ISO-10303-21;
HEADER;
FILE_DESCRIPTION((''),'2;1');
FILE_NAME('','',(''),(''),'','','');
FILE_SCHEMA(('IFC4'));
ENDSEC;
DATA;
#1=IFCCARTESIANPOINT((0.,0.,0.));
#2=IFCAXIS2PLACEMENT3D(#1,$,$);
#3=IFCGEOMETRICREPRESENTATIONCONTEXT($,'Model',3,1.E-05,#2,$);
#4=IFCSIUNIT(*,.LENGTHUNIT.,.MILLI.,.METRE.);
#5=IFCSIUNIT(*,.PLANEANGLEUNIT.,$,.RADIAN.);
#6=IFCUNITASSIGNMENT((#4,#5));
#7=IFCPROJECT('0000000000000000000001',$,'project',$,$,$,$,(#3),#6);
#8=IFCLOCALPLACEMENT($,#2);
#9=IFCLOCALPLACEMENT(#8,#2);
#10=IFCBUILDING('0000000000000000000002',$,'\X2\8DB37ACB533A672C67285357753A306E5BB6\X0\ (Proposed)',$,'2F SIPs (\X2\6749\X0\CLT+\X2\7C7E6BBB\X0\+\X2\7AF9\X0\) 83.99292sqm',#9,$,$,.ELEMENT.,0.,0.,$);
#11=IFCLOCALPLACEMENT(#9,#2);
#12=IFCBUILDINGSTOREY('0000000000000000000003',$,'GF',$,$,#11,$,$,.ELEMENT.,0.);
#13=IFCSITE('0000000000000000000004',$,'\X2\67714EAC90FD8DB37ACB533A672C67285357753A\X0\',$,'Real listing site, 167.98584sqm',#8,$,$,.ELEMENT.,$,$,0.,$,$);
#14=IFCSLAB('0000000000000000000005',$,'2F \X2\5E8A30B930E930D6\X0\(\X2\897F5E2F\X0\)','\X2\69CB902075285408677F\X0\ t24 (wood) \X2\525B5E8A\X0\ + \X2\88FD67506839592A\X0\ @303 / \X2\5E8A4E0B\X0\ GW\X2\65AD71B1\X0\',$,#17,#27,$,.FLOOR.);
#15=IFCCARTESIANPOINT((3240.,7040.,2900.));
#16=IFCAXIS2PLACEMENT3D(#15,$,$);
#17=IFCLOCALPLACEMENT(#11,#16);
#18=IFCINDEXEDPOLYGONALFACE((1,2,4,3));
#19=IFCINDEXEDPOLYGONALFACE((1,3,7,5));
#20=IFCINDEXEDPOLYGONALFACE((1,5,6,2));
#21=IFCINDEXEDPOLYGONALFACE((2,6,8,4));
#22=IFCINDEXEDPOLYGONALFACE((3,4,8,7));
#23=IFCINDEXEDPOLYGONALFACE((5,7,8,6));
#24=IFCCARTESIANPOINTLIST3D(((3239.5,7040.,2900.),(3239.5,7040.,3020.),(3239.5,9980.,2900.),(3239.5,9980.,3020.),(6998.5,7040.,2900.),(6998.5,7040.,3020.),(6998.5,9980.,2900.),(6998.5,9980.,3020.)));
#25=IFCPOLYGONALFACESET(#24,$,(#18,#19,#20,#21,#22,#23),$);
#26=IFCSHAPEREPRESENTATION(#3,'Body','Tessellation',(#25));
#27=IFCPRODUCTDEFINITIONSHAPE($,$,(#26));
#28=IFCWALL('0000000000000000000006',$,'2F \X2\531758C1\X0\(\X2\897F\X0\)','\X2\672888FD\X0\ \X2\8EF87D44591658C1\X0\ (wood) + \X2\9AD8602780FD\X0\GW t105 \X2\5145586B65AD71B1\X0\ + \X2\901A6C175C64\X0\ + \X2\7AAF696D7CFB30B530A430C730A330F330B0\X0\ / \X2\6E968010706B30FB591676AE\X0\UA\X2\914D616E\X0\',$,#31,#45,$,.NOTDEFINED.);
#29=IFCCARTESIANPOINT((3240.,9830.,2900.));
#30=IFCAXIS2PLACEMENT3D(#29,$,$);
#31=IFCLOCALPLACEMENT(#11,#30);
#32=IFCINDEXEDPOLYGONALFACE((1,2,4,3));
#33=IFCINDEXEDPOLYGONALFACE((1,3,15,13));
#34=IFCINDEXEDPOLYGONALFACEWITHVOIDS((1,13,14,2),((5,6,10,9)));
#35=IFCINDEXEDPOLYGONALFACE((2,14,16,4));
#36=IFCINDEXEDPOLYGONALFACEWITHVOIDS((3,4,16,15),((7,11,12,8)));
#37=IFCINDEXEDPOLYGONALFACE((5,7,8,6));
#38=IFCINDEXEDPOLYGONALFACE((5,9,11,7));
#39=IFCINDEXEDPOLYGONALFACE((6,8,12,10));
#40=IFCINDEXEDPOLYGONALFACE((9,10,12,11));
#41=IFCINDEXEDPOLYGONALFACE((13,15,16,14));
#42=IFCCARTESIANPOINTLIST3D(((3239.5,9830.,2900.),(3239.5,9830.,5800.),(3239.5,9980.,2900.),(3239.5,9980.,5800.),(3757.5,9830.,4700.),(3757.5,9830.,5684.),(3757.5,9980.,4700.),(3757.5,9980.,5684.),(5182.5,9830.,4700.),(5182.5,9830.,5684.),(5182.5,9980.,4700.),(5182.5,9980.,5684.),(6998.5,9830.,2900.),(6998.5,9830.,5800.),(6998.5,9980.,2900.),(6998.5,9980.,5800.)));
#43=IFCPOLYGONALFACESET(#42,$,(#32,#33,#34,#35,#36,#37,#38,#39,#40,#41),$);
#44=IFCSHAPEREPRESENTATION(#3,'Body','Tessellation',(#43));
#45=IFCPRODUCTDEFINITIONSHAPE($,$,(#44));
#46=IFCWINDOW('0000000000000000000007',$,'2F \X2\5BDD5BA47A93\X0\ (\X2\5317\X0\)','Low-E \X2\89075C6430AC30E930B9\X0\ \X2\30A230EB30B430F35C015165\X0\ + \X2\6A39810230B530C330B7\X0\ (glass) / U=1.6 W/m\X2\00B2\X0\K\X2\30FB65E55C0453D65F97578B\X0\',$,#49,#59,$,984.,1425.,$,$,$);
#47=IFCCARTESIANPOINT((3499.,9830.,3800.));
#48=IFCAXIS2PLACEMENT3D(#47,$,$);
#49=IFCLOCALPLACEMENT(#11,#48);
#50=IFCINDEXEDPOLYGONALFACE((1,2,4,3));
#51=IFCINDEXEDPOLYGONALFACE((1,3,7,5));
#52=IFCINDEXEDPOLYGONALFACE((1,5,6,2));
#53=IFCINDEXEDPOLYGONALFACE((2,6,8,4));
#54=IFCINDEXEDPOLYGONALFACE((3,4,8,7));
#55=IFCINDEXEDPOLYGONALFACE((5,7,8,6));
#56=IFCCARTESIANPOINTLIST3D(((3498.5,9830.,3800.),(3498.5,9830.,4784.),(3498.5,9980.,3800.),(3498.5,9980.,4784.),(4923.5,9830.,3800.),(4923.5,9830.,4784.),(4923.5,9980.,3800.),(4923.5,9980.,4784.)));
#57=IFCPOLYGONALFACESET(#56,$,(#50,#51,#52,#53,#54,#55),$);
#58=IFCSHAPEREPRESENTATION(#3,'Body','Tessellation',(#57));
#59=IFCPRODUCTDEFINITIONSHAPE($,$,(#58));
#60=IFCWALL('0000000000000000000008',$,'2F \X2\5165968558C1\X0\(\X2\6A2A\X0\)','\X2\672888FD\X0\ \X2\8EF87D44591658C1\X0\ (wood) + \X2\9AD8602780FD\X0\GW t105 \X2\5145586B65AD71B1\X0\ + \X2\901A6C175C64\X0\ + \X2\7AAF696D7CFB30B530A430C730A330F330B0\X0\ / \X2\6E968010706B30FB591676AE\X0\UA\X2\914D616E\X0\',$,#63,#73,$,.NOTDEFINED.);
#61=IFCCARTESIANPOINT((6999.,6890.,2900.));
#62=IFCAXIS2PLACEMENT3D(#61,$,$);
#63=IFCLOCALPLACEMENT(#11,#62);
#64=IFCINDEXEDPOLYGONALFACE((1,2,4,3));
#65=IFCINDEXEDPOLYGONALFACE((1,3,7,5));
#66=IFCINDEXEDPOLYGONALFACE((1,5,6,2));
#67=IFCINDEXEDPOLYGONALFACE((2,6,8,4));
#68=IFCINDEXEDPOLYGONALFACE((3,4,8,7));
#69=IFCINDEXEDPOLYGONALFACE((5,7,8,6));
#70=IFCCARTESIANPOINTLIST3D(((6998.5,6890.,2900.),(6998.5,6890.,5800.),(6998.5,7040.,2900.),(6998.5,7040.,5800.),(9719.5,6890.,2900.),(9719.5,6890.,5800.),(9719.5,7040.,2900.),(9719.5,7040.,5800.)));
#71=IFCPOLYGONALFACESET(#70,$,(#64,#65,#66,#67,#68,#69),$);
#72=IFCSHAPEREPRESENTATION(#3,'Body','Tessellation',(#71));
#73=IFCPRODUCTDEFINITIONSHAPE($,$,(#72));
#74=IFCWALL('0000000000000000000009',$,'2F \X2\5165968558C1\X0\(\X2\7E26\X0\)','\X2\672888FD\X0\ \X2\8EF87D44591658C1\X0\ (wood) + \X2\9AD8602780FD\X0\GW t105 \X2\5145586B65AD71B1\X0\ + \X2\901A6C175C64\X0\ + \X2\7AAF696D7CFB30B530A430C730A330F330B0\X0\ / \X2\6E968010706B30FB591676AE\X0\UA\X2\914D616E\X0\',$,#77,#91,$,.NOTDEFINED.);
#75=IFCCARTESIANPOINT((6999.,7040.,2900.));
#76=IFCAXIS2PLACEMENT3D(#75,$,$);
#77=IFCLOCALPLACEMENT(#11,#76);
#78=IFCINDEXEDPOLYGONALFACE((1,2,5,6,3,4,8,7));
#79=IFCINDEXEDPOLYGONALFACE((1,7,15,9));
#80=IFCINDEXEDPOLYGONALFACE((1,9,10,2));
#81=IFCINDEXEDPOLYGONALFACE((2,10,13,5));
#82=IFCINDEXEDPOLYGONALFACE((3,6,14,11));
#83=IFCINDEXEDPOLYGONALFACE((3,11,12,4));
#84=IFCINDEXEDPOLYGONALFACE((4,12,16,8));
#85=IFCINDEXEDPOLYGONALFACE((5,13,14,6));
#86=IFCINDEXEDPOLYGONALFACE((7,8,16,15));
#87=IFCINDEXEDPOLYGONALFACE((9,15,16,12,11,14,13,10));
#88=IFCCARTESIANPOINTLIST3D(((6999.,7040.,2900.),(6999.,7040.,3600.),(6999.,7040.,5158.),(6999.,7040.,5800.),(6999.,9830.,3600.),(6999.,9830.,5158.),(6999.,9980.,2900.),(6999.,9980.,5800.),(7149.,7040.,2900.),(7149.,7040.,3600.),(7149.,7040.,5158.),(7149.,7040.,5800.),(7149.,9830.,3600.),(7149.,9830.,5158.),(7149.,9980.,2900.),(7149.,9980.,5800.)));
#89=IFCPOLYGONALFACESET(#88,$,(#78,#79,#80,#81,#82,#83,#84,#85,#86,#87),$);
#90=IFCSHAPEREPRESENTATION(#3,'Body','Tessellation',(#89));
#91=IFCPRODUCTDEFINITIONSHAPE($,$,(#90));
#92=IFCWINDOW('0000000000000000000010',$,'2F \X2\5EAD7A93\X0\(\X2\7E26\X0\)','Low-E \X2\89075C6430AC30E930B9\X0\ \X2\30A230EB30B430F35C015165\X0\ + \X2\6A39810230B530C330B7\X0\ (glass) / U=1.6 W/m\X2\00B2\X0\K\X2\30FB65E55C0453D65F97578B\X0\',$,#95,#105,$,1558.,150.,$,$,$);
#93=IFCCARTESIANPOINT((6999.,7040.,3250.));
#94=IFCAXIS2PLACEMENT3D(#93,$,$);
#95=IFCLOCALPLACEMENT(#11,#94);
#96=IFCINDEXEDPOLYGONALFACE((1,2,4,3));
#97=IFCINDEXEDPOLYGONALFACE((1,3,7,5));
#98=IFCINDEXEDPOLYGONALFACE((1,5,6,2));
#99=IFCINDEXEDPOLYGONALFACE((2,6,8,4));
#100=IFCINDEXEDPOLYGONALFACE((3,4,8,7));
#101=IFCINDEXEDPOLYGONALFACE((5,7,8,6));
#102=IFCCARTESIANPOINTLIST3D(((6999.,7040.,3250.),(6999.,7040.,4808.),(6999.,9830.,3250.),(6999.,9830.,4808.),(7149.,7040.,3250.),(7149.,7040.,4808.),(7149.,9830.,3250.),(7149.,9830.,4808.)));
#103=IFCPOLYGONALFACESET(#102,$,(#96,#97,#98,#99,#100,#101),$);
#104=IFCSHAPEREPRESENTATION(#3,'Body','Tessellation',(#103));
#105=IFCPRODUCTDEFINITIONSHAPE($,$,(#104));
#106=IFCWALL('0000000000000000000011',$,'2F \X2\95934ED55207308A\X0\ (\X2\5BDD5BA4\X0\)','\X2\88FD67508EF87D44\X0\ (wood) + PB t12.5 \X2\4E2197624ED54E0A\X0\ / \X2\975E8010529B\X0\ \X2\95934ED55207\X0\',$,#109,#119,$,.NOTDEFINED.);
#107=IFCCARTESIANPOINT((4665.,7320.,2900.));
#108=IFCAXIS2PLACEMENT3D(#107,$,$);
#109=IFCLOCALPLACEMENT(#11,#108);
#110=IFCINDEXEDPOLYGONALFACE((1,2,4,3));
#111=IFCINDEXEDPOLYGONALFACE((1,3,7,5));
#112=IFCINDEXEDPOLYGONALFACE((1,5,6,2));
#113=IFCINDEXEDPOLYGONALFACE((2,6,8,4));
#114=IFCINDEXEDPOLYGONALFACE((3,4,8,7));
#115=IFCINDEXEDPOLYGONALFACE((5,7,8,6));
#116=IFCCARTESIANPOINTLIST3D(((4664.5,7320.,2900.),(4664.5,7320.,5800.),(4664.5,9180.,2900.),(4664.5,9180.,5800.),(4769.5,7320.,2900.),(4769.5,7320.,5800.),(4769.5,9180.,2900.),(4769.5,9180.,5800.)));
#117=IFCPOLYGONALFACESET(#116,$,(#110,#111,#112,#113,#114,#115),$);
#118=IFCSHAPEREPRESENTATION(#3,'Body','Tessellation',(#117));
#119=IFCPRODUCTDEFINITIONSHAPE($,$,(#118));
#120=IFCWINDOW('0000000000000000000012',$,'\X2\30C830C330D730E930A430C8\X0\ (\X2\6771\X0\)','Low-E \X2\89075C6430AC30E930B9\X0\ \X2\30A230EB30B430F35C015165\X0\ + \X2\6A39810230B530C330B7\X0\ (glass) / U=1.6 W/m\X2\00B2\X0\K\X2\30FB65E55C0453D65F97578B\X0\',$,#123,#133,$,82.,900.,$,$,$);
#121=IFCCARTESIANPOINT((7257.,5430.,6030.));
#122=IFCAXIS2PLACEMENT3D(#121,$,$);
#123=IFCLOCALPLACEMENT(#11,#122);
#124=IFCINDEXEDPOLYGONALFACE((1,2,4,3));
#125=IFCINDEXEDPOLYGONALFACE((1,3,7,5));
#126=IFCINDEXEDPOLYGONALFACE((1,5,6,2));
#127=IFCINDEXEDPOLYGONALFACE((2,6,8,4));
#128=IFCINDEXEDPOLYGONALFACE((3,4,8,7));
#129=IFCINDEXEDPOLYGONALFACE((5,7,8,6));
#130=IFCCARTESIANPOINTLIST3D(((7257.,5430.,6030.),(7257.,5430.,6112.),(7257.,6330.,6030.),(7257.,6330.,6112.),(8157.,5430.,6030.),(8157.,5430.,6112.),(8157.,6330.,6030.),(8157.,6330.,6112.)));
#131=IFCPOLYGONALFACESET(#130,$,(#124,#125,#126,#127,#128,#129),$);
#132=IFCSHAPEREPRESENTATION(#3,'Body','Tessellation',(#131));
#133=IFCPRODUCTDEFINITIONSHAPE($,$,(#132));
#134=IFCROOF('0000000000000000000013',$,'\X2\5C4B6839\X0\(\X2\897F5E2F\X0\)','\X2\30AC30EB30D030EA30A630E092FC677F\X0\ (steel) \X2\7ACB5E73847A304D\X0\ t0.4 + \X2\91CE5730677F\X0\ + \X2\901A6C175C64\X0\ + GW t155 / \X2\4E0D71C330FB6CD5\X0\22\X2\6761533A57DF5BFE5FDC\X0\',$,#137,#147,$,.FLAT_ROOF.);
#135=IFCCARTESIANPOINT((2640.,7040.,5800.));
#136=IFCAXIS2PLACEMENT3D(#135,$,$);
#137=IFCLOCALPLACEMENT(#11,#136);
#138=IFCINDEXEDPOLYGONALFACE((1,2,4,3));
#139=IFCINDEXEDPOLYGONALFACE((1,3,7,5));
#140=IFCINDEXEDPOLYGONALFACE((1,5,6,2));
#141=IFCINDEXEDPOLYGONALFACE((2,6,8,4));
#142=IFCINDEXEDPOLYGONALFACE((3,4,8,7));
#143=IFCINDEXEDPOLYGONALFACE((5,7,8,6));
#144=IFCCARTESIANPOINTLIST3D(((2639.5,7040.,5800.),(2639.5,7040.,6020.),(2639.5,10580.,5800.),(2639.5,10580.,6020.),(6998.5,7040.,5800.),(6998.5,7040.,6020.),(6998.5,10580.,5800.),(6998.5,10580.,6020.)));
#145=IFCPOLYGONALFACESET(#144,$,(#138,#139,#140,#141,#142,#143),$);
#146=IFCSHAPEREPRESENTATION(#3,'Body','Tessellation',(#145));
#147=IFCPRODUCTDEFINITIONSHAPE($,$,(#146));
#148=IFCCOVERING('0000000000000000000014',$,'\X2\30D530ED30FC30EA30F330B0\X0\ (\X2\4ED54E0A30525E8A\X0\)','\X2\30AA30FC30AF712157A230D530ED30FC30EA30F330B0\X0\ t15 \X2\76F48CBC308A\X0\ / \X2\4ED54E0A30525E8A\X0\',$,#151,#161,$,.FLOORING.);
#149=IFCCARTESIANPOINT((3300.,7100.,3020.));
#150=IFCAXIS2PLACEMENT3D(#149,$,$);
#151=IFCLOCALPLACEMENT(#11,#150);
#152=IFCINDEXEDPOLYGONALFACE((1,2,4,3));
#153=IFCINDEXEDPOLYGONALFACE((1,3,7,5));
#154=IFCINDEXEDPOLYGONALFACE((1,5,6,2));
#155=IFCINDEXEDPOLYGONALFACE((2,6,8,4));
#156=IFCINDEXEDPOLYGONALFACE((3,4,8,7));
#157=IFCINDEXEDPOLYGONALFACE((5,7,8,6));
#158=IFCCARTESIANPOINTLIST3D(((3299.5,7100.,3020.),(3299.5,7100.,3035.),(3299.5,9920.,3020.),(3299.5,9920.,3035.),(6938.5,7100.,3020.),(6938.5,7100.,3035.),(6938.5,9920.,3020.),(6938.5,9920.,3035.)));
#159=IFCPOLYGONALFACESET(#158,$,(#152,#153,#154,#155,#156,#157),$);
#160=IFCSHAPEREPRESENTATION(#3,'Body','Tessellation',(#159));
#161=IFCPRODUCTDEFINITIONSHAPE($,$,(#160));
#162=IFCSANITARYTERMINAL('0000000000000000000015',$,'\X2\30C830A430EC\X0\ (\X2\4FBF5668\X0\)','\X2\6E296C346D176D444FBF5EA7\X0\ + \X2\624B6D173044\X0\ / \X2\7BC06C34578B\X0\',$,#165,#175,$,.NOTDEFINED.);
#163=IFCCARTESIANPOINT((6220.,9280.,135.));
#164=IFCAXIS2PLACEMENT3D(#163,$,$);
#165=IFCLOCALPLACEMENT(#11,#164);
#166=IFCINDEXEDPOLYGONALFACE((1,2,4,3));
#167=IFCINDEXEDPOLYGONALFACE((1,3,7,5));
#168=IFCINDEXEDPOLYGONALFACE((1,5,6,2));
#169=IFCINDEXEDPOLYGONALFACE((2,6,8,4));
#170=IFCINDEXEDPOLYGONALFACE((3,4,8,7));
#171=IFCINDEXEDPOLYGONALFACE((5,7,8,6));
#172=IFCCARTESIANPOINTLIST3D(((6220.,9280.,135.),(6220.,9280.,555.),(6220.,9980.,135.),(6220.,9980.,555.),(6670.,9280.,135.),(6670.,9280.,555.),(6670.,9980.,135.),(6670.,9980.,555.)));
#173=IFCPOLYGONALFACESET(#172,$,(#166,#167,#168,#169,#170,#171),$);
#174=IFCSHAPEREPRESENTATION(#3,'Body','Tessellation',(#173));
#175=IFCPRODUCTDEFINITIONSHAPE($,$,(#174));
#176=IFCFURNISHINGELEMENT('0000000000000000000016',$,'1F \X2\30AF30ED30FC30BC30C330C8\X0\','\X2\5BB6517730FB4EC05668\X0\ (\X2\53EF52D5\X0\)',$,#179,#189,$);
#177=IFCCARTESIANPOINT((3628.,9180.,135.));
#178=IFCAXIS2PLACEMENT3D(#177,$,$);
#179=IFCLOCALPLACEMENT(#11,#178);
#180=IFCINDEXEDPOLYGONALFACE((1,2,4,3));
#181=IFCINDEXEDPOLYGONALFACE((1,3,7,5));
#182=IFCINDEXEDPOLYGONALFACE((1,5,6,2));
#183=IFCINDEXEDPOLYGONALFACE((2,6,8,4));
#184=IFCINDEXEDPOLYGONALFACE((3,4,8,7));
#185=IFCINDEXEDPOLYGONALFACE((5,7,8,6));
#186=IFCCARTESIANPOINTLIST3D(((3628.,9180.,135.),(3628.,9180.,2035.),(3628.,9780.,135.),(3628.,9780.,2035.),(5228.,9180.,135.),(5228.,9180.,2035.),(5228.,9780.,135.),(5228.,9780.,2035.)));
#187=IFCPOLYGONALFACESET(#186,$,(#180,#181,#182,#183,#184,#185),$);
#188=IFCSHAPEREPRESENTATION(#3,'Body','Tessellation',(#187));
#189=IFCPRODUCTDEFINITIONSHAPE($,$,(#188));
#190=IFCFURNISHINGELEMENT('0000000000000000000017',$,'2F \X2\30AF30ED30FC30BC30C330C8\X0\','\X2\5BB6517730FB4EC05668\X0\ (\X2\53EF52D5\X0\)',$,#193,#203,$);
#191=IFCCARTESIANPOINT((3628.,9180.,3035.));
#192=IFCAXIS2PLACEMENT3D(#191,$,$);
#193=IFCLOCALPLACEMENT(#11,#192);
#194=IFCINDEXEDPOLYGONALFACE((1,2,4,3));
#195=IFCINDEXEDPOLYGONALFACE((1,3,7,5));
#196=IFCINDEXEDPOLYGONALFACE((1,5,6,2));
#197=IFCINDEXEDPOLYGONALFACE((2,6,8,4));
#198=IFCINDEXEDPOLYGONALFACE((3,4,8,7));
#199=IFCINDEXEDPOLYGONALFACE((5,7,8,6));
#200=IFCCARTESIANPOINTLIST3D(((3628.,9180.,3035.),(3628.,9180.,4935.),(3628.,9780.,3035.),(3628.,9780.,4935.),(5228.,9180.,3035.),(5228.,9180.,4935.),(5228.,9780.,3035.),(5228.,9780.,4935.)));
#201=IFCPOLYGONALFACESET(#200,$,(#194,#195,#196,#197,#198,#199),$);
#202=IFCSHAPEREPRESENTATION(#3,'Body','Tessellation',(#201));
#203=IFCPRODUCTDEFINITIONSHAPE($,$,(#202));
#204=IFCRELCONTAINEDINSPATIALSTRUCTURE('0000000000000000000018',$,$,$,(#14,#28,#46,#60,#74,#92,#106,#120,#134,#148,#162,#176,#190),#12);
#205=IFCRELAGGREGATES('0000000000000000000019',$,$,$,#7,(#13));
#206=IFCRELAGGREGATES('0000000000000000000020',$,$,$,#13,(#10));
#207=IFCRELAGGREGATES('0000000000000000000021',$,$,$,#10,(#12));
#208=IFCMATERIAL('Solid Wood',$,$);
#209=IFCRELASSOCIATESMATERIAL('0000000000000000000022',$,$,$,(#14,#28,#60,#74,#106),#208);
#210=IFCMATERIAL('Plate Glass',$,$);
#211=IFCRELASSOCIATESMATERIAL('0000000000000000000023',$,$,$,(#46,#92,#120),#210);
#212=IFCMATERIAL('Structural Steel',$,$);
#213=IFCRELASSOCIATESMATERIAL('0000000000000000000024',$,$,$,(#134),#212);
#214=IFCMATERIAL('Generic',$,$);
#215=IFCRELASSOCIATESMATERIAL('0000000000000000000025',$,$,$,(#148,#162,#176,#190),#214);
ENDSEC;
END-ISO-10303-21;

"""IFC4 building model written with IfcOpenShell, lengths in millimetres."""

from ifc_helpers import new_model, si_unit, frame, frame_2d, origin, place, context, project, spatial, rectangle, extrude, material, element, fill, save


model = new_model("IFC4")

# Units and contexts
model_context = context("Model", 3, precision=1e-05, world=origin())
ifc_project = project(units=[si_unit("LENGTHUNIT", "METRE", prefix="MILLI"), si_unit("PLANEANGLEUNIT", "RADIAN")], contexts=[model_context])

# Site, building, storey
site_placement = place(None, origin())
site = spatial("IfcSite", under=ifc_project, at=site_placement, Name="東京都足立区本木南町", ObjectType="Real listing site, 167.98584sqm", CompositionType="ELEMENT", RefElevation=0.0)
building_placement = place(site_placement, origin())
building = spatial("IfcBuilding", under=site, at=building_placement, Name="足立区本木南町の家 (Proposed)", ObjectType="2F SIPs (杉CLT+籾殻+竹) 83.99292sqm", CompositionType="ELEMENT", ElevationOfRefHeight=0.0, ElevationOfTerrain=0.0)
storey_placement = place(building_placement, origin())
storey = spatial("IfcBuildingStorey", under=building, at=storey_placement, Name="GF", CompositionType="ELEMENT", Elevation=0.0)

# Slab
ifc_material_1 = material(Name="Solid Wood")
slab_placement = place(storey_placement, frame((3240.0, 7040.0, 2900.0)))
element("IfcSlab", 1, at=slab_placement, inside=storey, material=ifc_material_1, Name="2F 床スラブ(西帯)", Description="構造用合板 t24 (wood) 剛床 + 製材根太 @303 / 床下 GW断熱", PredefinedType="FLOOR", context=model_context, shape_type="SweptSolid", body=[
    extrude(rectangle(XDim=3759.0, YDim=2940.0, at=frame_2d((1879.0, 1470.0))), frame((3240.0, 7040.0, 2900.0)), (0.0, 0.0, 1.0), 120.0),
])

# Wall, opening, window
wall_1_placement = place(storey_placement, frame((3240.0, 9830.0, 2900.0)))
wall_1 = element("IfcWall", 2, at=wall_1_placement, inside=storey, material=ifc_material_1, Name="2F 北壁(西)", Description="木製 軸組外壁 (wood) + 高性能GW t105 充填断熱 + 通気層 + 窯業系サイディング / 準耐火・外皮UA配慮", PredefinedType="NOTDEFINED", context=model_context, shape_type="SweptSolid", body=[
    extrude(rectangle(XDim=3759.0, YDim=150.0, at=frame_2d((1879.0, 75.0))), frame((3240.0, 9830.0, 2900.0)), (0.0, 0.0, 1.0), 2900.0),
])
opening_1_placement = place(storey_placement, frame((3499.0, 9830.0, 3800.0)))
opening_1 = element("IfcOpeningElement", 3, at=opening_1_placement, cuts=wall_1, PredefinedType="NOTDEFINED", context=model_context, shape_type="SweptSolid", body=[
    extrude(rectangle(XDim=1425.0, YDim=150.0, at=frame_2d((712.0, 75.0))), frame((3499.0, 9830.0, 3800.0)), (0.0, 0.0, 1.0), 984.0),
])
ifc_material_2 = material(Name="Plate Glass")
window_1_placement = place(storey_placement, frame((3499.0, 9830.0, 3800.0)))
window_1 = element("IfcWindow", 4, at=window_1_placement, inside=storey, material=ifc_material_2, Name="2F 寝室窓 (北)", Description="Low-E 複層ガラス アルゴン封入 + 樹脂サッシ (glass) / U=1.6 W/m²K・日射取得型", OverallHeight=984.0, OverallWidth=1425.0, context=model_context, shape_type="SweptSolid", body=[
    extrude(rectangle(XDim=1425.0, YDim=150.0, at=frame_2d((712.0, 75.0))), frame((3499.0, 9830.0, 3800.0)), (0.0, 0.0, 1.0), 984.0),
])
fill(opening_1, window_1)

# Wall
wall_2_placement = place(storey_placement, frame((6999.0, 6890.0, 2900.0)))
element("IfcWall", 5, at=wall_2_placement, inside=storey, material=ifc_material_1, Name="2F 入隅壁(横)", Description="木製 軸組外壁 (wood) + 高性能GW t105 充填断熱 + 通気層 + 窯業系サイディング / 準耐火・外皮UA配慮", PredefinedType="NOTDEFINED", context=model_context, shape_type="SweptSolid", body=[
    extrude(rectangle(XDim=2721.0, YDim=150.0, at=frame_2d((1360.0, 75.0))), frame((6999.0, 6890.0, 2900.0)), (0.0, 0.0, 1.0), 2900.0),
])

# Wall, opening, window
wall_3_placement = place(storey_placement, frame((6999.0, 7040.0, 2900.0)))
wall_3 = element("IfcWall", 6, at=wall_3_placement, inside=storey, material=ifc_material_1, Name="2F 入隅壁(縦)", Description="木製 軸組外壁 (wood) + 高性能GW t105 充填断熱 + 通気層 + 窯業系サイディング / 準耐火・外皮UA配慮", PredefinedType="NOTDEFINED", context=model_context, shape_type="SweptSolid", body=[
    extrude(rectangle(XDim=150.0, YDim=2940.0, at=frame_2d((75.0, 1470.0))), frame((6999.0, 7040.0, 2900.0)), (0.0, 0.0, 1.0), 2900.0),
])
opening_2_placement = place(storey_placement, frame((6999.0, 7040.0, 3250.0)))
opening_2 = element("IfcOpeningElement", 7, at=opening_2_placement, cuts=wall_3, PredefinedType="NOTDEFINED", context=model_context, shape_type="SweptSolid", body=[
    extrude(rectangle(XDim=150.0, YDim=2790.0, at=frame_2d((75.0, 1395.0))), frame((6999.0, 7040.0, 3250.0)), (0.0, 0.0, 1.0), 1558.0),
])
window_2_placement = place(storey_placement, frame((6999.0, 7040.0, 3250.0)))
window_2 = element("IfcWindow", 8, at=window_2_placement, inside=storey, material=ifc_material_2, Name="2F 庭窓(縦)", Description="Low-E 複層ガラス アルゴン封入 + 樹脂サッシ (glass) / U=1.6 W/m²K・日射取得型", OverallHeight=1558.0, OverallWidth=150.0, context=model_context, shape_type="SweptSolid", body=[
    extrude(rectangle(XDim=150.0, YDim=2790.0, at=frame_2d((75.0, 1395.0))), frame((6999.0, 7040.0, 3250.0)), (0.0, 0.0, 1.0), 1558.0),
])
fill(opening_2, window_2)

# Wall
wall_4_placement = place(storey_placement, frame((4665.0, 7320.0, 2900.0)))
element("IfcWall", 9, at=wall_4_placement, inside=storey, material=ifc_material_1, Name="2F 間仕切り (寝室)", Description="製材軸組 (wood) + PB t12.5 両面仕上 / 非耐力 間仕切", PredefinedType="NOTDEFINED", context=model_context, shape_type="SweptSolid", body=[
    extrude(rectangle(XDim=105.0, YDim=1860.0, at=frame_2d((52.0, 930.0))), frame((4665.0, 7320.0, 2900.0)), (0.0, 0.0, 1.0), 2900.0),
])

# Window
window_3_placement = place(storey_placement, frame((7257.0, 5430.0, 6030.0)))
element("IfcWindow", 10, at=window_3_placement, inside=storey, material=ifc_material_2, Name="トップライト (東)", Description="Low-E 複層ガラス アルゴン封入 + 樹脂サッシ (glass) / U=1.6 W/m²K・日射取得型", OverallHeight=82.0, OverallWidth=900.0, context=model_context, shape_type="SweptSolid", body=[
    extrude(rectangle(XDim=900.0, YDim=900.0, at=frame_2d((450.0, 450.0))), frame((7257.0, 5430.0, 6030.0)), (0.0, 0.0, 1.0), 82.0),
])

# Roof
ifc_material_3 = material(Name="Structural Steel")
for number, where, name in (
    (11, (2640.0, 7040.0, 5800.0), "屋根(西帯)"),
):
    element("IfcRoof", number, at=place(storey_placement, frame(where)), inside=storey, material=ifc_material_3, Name=name, Description="ガルバリウム鋼板 (steel) 立平葺き t0.4 + 野地板 + 通気層 + GW t155 / 不燃・法22条区域対応", PredefinedType="FLAT_ROOF", context=model_context, shape_type="SweptSolid", body=[
        extrude(rectangle(XDim=4359.0, YDim=3540.0, at=frame_2d((2179.0, 1770.0))), frame((2640.0, 7040.0, 5800.0)), (0.0, 0.0, 1.0), 220.0),
    ])

# Covering
ifc_material_4 = material(Name="Generic")
covering_placement = place(storey_placement, frame((3300.0, 7100.0, 3020.0)))
element("IfcCovering", 12, at=covering_placement, inside=storey, material=ifc_material_4, Name="フローリング (仕上げ床)", Description="オーク無垢フローリング t15 直貼り / 仕上げ床", PredefinedType="FLOORING", context=model_context, shape_type="SweptSolid", body=[
    extrude(rectangle(XDim=3639.0, YDim=2820.0, at=frame_2d((1819.0, 1410.0))), frame((3300.0, 7100.0, 3020.0)), (0.0, 0.0, 1.0), 15.0),
])

# Sanitary terminal
sanitary_terminal_placement = place(storey_placement, frame((6220.0, 9280.0, 135.0)))
element("IfcSanitaryTerminal", 13, at=sanitary_terminal_placement, inside=storey, material=ifc_material_4, Name="トイレ (便器)", Description="温水洗浄便座 + 手洗い / 節水型", PredefinedType="NOTDEFINED", context=model_context, shape_type="SweptSolid", body=[
    extrude(rectangle(XDim=450.0, YDim=700.0, at=frame_2d((225.0, 350.0))), frame((6220.0, 9280.0, 135.0)), (0.0, 0.0, 1.0), 420.0),
])

# Furnishing elements
furnishing_1_placement = place(storey_placement, frame((3628.0, 9180.0, 135.0)))
element("IfcFurnishingElement", 14, at=furnishing_1_placement, inside=storey, material=ifc_material_4, Name="1F クローゼット", Description="家具・什器 (可動)", context=model_context, shape_type="SweptSolid", body=[
    extrude(rectangle(XDim=1600.0, YDim=600.0, at=frame_2d((800.0, 300.0))), frame((3628.0, 9180.0, 135.0)), (0.0, 0.0, 1.0), 1900.0),
])
furnishing_2_placement = place(storey_placement, frame((3628.0, 9180.0, 3035.0)))
element("IfcFurnishingElement", 15, at=furnishing_2_placement, inside=storey, material=ifc_material_4, Name="2F クローゼット", Description="家具・什器 (可動)", context=model_context, shape_type="SweptSolid", body=[
    extrude(rectangle(XDim=1600.0, YDim=600.0, at=frame_2d((800.0, 300.0))), frame((3628.0, 9180.0, 3035.0)), (0.0, 0.0, 1.0), 1900.0),
])

save(model, "model.ifc")
